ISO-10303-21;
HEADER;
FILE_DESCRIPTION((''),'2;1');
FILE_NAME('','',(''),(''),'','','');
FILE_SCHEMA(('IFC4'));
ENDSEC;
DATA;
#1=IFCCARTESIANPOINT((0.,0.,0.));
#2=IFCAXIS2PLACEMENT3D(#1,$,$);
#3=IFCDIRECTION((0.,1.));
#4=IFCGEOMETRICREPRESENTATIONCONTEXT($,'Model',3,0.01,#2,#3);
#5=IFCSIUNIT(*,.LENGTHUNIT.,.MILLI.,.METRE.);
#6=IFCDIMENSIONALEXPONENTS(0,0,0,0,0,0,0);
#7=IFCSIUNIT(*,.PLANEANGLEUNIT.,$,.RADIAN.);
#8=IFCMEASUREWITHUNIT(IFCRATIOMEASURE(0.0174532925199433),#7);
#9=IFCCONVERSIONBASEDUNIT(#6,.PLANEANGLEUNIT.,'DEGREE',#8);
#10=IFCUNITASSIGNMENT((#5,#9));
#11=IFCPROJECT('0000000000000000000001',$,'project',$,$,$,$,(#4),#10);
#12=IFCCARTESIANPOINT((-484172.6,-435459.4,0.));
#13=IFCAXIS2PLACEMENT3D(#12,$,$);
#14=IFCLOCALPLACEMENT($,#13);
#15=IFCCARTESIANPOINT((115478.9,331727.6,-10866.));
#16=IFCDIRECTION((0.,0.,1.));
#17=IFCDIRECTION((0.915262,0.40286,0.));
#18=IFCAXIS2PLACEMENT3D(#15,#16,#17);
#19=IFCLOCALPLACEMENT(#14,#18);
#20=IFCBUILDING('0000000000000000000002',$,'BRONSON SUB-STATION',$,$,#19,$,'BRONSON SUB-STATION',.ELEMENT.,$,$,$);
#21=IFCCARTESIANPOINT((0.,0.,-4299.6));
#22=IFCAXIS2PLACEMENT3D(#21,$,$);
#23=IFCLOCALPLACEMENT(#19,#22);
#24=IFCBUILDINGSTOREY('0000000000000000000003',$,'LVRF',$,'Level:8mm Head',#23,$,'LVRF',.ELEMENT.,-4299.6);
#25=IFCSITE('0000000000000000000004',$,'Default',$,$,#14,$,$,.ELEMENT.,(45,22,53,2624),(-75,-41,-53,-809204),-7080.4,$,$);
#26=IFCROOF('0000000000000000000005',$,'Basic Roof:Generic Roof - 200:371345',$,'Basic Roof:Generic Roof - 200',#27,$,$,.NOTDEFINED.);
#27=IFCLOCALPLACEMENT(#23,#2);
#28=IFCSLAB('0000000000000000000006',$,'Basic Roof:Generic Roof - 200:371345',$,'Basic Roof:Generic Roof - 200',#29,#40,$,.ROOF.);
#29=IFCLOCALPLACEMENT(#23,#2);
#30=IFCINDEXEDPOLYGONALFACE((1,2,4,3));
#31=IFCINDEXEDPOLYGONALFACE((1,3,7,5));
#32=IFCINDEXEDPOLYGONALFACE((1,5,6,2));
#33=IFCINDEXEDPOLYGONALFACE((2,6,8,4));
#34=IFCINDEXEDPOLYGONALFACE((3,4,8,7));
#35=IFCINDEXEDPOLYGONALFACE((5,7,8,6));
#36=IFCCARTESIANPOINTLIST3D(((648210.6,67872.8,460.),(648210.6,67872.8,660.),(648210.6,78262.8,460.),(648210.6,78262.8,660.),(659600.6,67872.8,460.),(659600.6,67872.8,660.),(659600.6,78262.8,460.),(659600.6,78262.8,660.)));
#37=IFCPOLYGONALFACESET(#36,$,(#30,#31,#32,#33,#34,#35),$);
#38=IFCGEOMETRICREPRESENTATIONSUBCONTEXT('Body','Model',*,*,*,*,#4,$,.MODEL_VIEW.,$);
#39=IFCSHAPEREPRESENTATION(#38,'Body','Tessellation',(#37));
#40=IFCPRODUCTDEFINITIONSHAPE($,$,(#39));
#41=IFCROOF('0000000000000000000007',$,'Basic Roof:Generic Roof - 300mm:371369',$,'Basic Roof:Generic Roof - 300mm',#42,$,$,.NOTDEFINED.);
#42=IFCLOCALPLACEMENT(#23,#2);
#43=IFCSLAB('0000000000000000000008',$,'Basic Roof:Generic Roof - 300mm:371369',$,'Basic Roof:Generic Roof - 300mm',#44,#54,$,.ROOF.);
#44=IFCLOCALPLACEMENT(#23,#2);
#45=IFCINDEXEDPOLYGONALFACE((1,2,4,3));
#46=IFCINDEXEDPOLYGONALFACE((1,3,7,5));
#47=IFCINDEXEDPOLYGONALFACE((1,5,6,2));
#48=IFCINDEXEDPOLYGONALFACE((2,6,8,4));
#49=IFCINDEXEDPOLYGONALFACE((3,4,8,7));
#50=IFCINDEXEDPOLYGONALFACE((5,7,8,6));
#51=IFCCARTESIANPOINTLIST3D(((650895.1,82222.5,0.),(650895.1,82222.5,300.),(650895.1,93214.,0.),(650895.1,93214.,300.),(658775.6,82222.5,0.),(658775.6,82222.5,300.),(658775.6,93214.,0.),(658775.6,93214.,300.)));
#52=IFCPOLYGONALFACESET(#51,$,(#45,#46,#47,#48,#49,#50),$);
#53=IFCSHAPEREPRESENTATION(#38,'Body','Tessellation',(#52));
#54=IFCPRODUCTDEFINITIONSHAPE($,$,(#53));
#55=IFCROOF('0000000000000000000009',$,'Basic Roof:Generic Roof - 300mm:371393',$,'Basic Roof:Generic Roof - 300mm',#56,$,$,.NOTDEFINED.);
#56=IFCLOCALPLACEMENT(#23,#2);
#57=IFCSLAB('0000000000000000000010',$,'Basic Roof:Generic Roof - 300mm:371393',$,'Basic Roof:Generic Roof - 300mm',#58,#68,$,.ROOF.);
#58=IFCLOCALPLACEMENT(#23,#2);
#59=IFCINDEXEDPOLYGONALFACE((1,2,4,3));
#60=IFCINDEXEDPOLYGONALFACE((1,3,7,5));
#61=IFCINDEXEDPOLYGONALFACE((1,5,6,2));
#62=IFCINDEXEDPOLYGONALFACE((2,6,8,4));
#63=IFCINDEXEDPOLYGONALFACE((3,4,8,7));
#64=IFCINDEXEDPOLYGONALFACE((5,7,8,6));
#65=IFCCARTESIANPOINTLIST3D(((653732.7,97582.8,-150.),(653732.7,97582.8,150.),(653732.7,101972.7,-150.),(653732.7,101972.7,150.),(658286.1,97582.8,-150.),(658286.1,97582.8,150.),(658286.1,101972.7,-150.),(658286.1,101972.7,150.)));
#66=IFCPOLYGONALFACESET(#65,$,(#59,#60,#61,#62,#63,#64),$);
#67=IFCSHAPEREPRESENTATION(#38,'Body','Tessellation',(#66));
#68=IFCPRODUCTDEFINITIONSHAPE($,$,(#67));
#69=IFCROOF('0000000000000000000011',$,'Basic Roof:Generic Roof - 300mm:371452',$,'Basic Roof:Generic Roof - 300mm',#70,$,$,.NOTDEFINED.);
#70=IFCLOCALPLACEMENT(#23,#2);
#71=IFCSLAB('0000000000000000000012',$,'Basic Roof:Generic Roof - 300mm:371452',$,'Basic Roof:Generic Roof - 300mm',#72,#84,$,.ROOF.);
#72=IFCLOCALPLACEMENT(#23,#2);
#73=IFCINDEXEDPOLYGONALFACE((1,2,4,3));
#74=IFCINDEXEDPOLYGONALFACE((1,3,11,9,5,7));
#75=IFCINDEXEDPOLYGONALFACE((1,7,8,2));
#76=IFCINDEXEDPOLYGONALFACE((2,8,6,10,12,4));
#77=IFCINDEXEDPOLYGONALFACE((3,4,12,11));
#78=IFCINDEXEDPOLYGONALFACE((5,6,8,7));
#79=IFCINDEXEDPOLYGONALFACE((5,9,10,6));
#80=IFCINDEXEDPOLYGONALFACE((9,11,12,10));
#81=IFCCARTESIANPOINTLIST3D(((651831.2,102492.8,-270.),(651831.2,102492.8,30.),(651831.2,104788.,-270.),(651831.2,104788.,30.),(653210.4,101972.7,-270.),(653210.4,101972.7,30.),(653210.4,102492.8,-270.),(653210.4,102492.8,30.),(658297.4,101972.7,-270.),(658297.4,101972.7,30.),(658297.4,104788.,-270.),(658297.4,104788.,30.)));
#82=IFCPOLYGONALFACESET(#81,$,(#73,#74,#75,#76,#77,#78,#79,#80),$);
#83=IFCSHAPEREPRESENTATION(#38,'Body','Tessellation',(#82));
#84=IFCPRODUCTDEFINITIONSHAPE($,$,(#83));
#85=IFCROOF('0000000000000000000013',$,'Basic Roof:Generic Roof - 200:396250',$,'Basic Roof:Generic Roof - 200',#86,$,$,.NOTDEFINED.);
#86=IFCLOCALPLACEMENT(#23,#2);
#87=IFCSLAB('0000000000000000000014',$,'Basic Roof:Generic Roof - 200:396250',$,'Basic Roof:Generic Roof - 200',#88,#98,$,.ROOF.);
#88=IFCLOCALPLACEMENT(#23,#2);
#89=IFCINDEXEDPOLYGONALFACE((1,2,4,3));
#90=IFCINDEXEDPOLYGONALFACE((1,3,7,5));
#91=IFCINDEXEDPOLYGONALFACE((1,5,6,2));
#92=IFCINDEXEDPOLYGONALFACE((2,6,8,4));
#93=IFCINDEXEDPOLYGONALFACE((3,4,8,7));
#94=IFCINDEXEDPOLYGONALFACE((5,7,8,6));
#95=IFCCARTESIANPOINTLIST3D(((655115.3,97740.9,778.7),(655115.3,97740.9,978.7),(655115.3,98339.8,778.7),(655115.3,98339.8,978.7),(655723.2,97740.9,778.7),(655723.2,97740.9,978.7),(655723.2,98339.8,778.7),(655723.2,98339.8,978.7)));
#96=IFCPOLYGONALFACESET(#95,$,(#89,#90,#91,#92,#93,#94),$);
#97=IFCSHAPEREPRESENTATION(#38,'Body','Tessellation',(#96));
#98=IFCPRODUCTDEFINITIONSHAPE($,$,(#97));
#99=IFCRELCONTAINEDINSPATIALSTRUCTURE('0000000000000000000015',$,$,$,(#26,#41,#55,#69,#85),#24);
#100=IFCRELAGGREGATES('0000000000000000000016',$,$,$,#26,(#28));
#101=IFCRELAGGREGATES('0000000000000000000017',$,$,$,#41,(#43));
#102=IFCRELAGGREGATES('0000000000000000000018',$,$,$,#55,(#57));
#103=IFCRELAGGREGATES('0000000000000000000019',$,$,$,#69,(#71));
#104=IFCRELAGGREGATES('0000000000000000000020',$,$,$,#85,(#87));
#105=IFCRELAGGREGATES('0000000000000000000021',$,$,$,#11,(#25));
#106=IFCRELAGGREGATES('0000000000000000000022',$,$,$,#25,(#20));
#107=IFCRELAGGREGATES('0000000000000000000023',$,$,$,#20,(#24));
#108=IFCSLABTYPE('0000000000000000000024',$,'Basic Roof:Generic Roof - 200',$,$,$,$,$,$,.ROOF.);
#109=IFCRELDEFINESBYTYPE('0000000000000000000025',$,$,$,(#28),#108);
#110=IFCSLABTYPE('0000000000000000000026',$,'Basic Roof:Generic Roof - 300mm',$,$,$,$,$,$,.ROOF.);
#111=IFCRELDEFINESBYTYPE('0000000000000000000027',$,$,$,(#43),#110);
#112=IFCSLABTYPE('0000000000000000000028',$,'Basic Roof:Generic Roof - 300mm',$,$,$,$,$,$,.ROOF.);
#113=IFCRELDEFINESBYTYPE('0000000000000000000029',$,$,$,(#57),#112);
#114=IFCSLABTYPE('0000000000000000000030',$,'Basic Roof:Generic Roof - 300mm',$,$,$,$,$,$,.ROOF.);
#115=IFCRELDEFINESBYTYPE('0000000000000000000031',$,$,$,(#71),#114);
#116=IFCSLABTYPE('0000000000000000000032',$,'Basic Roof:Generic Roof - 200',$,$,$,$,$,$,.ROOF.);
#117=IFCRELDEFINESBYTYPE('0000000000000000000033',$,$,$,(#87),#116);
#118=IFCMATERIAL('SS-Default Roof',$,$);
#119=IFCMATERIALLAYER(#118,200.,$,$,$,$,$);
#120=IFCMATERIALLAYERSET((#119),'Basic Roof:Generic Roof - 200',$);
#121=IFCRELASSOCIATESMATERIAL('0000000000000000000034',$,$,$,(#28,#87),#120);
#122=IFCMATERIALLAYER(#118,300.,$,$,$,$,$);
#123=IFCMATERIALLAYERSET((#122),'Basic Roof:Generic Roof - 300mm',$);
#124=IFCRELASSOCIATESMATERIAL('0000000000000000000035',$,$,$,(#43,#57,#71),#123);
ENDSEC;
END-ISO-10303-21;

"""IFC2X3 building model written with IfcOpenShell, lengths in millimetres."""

from ifc_helpers import new_model, entity, si_unit, converted_unit, direction, frame, frame_2d, origin, place, context, subcontext, project, spatial, polyline, rectangle, outline, extrude, material, layer, layer_set, type_object, element, aggregate, save


model = new_model("IFC2X3")

# Units and contexts
model_context = context("Model", 3, precision=0.01, world=origin(), true_north=direction((0.0, 1.0)))
body_context = subcontext(model_context, "Body", "Model", "MODEL_VIEW")
ifc_project = project(units=[si_unit("LENGTHUNIT", "METRE", prefix="MILLI"), converted_unit("PLANEANGLEUNIT", "DEGREE", entity("IfcRatioMeasure", 0.0174532925199433), si_unit("PLANEANGLEUNIT", "RADIAN"), dimensions=[0, 0, 0, 0, 0, 0, 0])], contexts=[model_context])

# Site, building, storey
site_placement = place(None, frame((-484172.6, -435459.4, 0.0)))
site = spatial("IfcSite", under=ifc_project, at=site_placement, Name="Default", CompositionType="ELEMENT", RefLatitude=(45, 22, 53, 2624), RefLongitude=(-75, -41, -53, -809204), RefElevation=-7080.4)
building_placement = place(site_placement, frame((115478.9, 331727.6, -10866.0), z_axis=(0.0, 0.0, 1.0), x_axis=(0.915262, 0.40286, 0.0)))
building = spatial("IfcBuilding", under=site, at=building_placement, Name="BRONSON SUB-STATION", LongName="BRONSON SUB-STATION", CompositionType="ELEMENT")
storey_placement = place(building_placement, frame((0.0, 0.0, -4299.6)))
storey = spatial("IfcBuildingStorey", under=building, at=storey_placement, Name="LVRF", ObjectType="Level:8mm Head", LongName="LVRF", CompositionType="ELEMENT", Elevation=-4299.6)

# Roofs, slabs
roof_1_placement = place(storey_placement, frame((648210.6, 67872.8, 460.0)))
roof_1 = element("IfcRoof", 1, at=roof_1_placement, inside=storey, Name="Basic Roof:Generic Roof - 200:371345", ObjectType="Basic Roof:Generic Roof - 200", ShapeType="NOTDEFINED")
ifc_material = material(Name="SS-Default Roof")
ifc_layer_1 = layer(ifc_material, 200.0)
ifc_layer_set_1 = layer_set([ifc_layer_1], Name="Basic Roof:Generic Roof - 200")
slab_type_1 = type_object("IfcSlabType", Name="Basic Roof:Generic Roof - 200", PredefinedType="ROOF")
slab_1_placement = place(roof_1_placement, origin())
slab_1 = element("IfcSlab", 2, at=slab_1_placement, type_object=slab_type_1, material=ifc_layer_set_1, Name="Basic Roof:Generic Roof - 200:371345", ObjectType="Basic Roof:Generic Roof - 200", PredefinedType="ROOF", context=body_context, shape_type="SweptSolid", body=[
    extrude(rectangle(XDim=10390.0, YDim=11390.0, at=frame_2d((0.0, 0.0), x_axis=(0.0, -1.0))), frame((5695.0, 5195.0, 0.0)), (0.0, 0.0, 1.0), 200.0),
])
aggregate(roof_1, [slab_1])
roof_2_placement = place(storey_placement, frame((650895.1, 82222.5, 0.0)))
roof_2 = element("IfcRoof", 3, at=roof_2_placement, inside=storey, Name="Basic Roof:Generic Roof - 300mm:371369", ObjectType="Basic Roof:Generic Roof - 300mm", ShapeType="NOTDEFINED")
ifc_layer_2 = layer(ifc_material, 300.0)
ifc_layer_set_2 = layer_set([ifc_layer_2], Name="Basic Roof:Generic Roof - 300mm")
slab_type_2 = type_object("IfcSlabType", Name="Basic Roof:Generic Roof - 300mm", PredefinedType="ROOF")
slab_2_placement = place(roof_2_placement, origin())
slab_2 = element("IfcSlab", 4, at=slab_2_placement, type_object=slab_type_2, material=ifc_layer_set_2, Name="Basic Roof:Generic Roof - 300mm:371369", ObjectType="Basic Roof:Generic Roof - 300mm", PredefinedType="ROOF", context=body_context, shape_type="SweptSolid", body=[
    extrude(rectangle(XDim=10991.5, YDim=7880.5, at=frame_2d((0.0, 0.0), x_axis=(0.0, -1.0))), frame((3940.2, 5495.7, 0.0)), (0.0, 0.0, 1.0), 300.0),
])
aggregate(roof_2, [slab_2])
roof_3_placement = place(storey_placement, frame((653732.7, 97582.8, -150.0)))
roof_3 = element("IfcRoof", 5, at=roof_3_placement, inside=storey, Name="Basic Roof:Generic Roof - 300mm:371393", ObjectType="Basic Roof:Generic Roof - 300mm", ShapeType="NOTDEFINED")
slab_type_3 = type_object("IfcSlabType", Name="Basic Roof:Generic Roof - 300mm", PredefinedType="ROOF")
slab_3_placement = place(roof_3_placement, origin())
slab_3 = element("IfcSlab", 6, at=slab_3_placement, type_object=slab_type_3, material=ifc_layer_set_2, Name="Basic Roof:Generic Roof - 300mm:371393", ObjectType="Basic Roof:Generic Roof - 300mm", PredefinedType="ROOF", context=body_context, shape_type="SweptSolid", body=[
    extrude(rectangle(XDim=4553.4, YDim=4389.9, at=frame_2d((0.0, 0.0), x_axis=(1.0, 0.0))), frame((2276.7, 2194.9, 0.0)), (0.0, 0.0, 1.0), 300.0),
])
aggregate(roof_3, [slab_3])
roof_4_placement = place(storey_placement, frame((651831.2, 101972.7, -270.0)))
roof_4 = element("IfcRoof", 7, at=roof_4_placement, inside=storey, Name="Basic Roof:Generic Roof - 300mm:371452", ObjectType="Basic Roof:Generic Roof - 300mm", ShapeType="NOTDEFINED")
slab_type_4 = type_object("IfcSlabType", Name="Basic Roof:Generic Roof - 300mm", PredefinedType="ROOF")
slab_4_placement = place(roof_4_placement, origin())
slab_4 = element("IfcSlab", 8, at=slab_4_placement, type_object=slab_type_4, material=ifc_layer_set_2, Name="Basic Roof:Generic Roof - 300mm:371452", ObjectType="Basic Roof:Generic Roof - 300mm", PredefinedType="ROOF", context=body_context, shape_type="SweptSolid", body=[
    extrude(outline(polyline([(-3233.1, 1407.6), (-3233.1, -887.5), (-1853.9, -887.5), (-1853.9, -1407.6), (3233.1, -1407.6), (3233.1, 1407.6), (-3233.1, 1407.6)])), frame((3233.1, 1407.6, 0.0)), (0.0, 0.0, 1.0), 300.0),
])
aggregate(roof_4, [slab_4])
roof_5_placement = place(storey_placement, frame((655115.3, 97740.9, 778.7)))
roof_5 = element("IfcRoof", 9, at=roof_5_placement, inside=storey, Name="Basic Roof:Generic Roof - 200:396250", ObjectType="Basic Roof:Generic Roof - 200", ShapeType="NOTDEFINED")
slab_type_5 = type_object("IfcSlabType", Name="Basic Roof:Generic Roof - 200", PredefinedType="ROOF")
slab_5_placement = place(roof_5_placement, origin())
slab_5 = element("IfcSlab", 10, at=slab_5_placement, type_object=slab_type_5, material=ifc_layer_set_1, Name="Basic Roof:Generic Roof - 200:396250", ObjectType="Basic Roof:Generic Roof - 200", PredefinedType="ROOF", context=body_context, shape_type="SweptSolid", body=[
    extrude(rectangle(XDim=598.8, YDim=607.9, at=frame_2d((0.0, 0.0), x_axis=(0.0, -1.0))), frame((303.9, 299.4, 0.0)), (0.0, 0.0, 1.0), 200.0),
])
aggregate(roof_5, [slab_5])

save(model, "model.ifc")
